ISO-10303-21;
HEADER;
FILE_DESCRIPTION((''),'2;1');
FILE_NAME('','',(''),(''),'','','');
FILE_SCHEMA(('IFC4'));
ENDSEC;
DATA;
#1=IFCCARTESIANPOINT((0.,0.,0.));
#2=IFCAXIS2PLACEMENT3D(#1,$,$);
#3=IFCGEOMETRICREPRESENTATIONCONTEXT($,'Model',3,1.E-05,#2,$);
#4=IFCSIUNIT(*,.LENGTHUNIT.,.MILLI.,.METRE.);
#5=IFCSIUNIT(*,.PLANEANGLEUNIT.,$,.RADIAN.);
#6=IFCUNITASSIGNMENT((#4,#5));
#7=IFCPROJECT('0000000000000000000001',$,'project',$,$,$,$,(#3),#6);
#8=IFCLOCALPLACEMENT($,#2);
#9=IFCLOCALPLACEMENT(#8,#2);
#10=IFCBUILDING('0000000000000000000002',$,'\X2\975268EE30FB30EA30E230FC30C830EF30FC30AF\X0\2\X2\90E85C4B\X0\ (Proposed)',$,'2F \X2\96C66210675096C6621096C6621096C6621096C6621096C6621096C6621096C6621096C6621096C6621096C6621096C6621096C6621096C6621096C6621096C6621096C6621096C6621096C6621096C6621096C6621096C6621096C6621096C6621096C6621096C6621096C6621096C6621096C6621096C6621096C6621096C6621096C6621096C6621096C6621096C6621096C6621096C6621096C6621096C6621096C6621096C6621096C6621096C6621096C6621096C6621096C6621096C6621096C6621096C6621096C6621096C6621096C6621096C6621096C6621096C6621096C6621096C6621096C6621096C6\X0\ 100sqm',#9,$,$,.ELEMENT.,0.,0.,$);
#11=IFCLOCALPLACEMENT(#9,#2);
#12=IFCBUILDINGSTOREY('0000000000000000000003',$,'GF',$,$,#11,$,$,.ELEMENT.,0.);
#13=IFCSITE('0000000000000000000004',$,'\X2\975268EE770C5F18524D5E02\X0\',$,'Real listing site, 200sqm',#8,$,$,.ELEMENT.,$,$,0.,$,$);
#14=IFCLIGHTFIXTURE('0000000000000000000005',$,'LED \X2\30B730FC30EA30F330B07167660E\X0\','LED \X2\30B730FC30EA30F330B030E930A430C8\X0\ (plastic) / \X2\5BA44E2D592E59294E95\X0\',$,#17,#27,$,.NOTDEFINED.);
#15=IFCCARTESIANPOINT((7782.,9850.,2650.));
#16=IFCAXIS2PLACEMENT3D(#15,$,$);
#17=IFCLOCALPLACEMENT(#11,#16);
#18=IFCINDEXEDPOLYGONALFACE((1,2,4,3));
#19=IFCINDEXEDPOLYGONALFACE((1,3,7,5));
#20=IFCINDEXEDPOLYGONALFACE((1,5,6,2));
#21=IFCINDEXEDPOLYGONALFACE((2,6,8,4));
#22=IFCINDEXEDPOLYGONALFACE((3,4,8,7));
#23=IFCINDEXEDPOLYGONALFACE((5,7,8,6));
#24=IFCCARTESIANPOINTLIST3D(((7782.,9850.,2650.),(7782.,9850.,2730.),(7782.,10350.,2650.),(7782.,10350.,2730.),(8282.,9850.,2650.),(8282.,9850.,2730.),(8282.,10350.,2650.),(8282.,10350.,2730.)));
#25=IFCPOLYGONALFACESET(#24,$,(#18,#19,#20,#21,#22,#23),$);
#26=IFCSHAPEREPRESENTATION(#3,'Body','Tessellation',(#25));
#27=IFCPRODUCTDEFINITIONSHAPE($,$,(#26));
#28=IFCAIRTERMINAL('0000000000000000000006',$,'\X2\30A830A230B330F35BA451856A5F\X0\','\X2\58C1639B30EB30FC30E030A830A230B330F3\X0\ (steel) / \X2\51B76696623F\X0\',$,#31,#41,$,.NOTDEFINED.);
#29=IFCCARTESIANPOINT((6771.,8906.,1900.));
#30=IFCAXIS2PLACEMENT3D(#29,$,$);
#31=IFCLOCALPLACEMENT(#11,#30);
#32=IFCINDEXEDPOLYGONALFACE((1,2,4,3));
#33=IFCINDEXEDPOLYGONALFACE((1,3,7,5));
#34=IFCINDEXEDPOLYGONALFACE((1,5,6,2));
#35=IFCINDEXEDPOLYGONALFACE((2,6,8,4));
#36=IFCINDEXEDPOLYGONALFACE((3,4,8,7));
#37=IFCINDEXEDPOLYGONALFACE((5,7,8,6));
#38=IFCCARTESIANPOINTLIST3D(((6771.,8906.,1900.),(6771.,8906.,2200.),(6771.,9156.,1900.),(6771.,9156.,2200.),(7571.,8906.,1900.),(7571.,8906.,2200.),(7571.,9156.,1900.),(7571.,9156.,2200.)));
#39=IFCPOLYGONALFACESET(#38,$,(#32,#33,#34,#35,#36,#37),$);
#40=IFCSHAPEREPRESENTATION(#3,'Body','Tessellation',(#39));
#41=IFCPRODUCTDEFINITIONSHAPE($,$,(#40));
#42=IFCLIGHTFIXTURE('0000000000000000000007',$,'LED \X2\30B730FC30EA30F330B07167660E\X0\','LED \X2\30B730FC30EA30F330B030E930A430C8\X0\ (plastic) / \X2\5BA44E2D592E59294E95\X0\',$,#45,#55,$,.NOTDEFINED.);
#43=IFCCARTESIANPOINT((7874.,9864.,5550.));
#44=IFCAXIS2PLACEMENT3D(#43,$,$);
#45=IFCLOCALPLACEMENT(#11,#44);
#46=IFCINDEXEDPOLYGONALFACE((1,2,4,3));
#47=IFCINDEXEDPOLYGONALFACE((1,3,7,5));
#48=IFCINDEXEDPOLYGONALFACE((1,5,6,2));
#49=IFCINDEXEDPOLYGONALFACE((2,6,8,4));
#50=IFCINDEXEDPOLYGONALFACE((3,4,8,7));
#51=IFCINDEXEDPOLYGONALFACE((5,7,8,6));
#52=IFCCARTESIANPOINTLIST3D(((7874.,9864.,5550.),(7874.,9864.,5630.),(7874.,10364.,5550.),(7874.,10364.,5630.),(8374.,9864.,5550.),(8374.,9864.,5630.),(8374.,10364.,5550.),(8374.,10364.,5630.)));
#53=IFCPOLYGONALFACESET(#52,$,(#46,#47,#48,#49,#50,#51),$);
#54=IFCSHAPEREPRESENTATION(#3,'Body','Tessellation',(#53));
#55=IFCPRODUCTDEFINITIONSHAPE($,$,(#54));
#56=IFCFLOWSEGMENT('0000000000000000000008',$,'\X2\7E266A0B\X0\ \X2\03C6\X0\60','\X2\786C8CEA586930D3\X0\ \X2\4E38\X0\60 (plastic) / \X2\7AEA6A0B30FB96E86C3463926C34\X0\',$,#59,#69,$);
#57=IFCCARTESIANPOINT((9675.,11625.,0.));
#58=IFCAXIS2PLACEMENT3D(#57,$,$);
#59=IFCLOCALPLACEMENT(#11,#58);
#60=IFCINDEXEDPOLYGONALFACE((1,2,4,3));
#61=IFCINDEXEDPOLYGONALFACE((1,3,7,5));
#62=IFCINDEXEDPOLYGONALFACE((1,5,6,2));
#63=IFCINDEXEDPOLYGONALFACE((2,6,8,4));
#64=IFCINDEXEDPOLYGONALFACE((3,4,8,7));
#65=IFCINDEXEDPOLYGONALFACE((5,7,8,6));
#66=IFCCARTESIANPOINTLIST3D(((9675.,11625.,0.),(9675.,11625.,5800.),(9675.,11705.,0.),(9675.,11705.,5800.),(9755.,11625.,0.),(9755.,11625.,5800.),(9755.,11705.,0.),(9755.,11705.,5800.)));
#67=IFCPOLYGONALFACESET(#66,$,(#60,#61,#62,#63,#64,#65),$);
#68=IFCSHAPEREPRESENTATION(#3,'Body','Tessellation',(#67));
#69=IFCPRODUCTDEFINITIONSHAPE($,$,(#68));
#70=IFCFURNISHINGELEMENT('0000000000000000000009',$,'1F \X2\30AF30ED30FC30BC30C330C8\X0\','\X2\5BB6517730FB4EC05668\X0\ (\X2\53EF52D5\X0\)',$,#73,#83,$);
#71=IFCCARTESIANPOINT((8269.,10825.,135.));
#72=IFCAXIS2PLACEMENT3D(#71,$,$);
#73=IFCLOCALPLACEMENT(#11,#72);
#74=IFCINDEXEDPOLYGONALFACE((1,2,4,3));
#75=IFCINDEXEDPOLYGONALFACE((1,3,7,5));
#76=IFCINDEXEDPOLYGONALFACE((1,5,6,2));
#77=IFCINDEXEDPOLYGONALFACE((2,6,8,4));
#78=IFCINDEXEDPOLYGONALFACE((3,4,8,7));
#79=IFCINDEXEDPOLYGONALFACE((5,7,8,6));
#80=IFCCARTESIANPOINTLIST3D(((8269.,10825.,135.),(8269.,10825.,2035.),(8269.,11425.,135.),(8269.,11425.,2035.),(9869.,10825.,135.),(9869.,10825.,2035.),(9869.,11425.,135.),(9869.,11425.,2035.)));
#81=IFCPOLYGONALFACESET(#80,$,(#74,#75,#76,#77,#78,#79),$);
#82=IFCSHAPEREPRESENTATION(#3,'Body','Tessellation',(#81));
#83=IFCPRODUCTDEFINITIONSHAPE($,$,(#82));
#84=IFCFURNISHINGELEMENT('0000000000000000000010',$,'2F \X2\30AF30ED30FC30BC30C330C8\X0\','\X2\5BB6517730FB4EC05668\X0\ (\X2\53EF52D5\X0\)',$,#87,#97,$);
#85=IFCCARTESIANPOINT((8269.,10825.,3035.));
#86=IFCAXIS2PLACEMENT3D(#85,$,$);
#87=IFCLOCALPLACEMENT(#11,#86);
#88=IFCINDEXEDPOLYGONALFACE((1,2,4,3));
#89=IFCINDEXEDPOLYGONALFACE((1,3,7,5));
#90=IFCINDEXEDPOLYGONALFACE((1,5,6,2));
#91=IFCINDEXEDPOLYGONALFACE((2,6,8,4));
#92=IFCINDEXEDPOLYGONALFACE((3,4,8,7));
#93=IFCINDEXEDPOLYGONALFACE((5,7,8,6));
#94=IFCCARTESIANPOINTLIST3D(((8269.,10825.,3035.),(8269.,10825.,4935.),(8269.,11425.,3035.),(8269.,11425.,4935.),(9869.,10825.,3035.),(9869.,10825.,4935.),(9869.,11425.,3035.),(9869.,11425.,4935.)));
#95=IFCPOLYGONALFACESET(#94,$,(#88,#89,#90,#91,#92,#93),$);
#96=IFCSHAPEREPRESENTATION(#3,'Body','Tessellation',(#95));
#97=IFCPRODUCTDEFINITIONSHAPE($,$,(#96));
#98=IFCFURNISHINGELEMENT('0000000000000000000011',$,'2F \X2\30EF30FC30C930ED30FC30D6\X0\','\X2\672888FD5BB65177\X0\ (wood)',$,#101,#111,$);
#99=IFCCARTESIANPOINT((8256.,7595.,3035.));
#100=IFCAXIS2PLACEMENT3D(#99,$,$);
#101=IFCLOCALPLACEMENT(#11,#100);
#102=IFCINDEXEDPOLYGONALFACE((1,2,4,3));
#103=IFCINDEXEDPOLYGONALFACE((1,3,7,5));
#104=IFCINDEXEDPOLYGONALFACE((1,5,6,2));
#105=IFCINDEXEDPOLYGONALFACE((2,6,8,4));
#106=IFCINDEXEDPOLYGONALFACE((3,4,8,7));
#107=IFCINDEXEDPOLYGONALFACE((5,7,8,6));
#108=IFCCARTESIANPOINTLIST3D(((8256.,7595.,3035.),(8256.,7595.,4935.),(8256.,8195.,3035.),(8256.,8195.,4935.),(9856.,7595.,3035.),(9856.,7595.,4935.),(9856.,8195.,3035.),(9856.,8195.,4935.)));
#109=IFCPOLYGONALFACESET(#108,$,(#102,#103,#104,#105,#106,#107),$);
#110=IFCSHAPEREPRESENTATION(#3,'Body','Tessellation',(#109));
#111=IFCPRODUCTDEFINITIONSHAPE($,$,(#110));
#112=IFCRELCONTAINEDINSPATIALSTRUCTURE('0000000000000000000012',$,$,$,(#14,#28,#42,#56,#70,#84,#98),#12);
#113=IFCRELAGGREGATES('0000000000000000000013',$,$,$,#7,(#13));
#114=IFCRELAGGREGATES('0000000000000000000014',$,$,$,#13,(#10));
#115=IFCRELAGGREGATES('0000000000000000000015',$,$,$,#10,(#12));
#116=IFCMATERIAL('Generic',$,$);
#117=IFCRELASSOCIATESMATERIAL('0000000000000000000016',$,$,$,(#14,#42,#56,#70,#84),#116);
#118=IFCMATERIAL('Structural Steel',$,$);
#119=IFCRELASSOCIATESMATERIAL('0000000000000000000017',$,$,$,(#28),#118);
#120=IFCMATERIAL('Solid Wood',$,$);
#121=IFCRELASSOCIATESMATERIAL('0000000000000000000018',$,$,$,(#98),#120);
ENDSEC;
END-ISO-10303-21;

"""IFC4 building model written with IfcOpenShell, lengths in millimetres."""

from ifc_helpers import new_model, si_unit, frame, frame_2d, origin, place, context, project, spatial, rectangle, extrude, material, element, save


model = new_model("IFC4")

# Units and contexts
model_context = context("Model", 3, precision=1e-05, world=origin())
ifc_project = project(units=[si_unit("LENGTHUNIT", "METRE", prefix="MILLI"), si_unit("PLANEANGLEUNIT", "RADIAN")], contexts=[model_context])

# Site, building, storey
site_placement = place(None, origin())
site = spatial("IfcSite", under=ifc_project, at=site_placement, Name="青森県弘前市", ObjectType="Real listing site, 200sqm", CompositionType="ELEMENT", RefElevation=0.0)
building_placement = place(site_placement, origin())
building = spatial("IfcBuilding", under=site, at=building_placement, Name="青森・リモートワーク2部屋 (Proposed)", ObjectType="2F 集成材集成集成集成集成集成集成集成集成集成集成集成集成集成集成集成集成集成集成集成集成集成集成集成集成集成集成集成集成集成集成集成集成集成集成集成集成集成集成集成集成集成集成集成集成集成集成集成集成集成集成集成集成集成集成集成集成集成集成集 100sqm", CompositionType="ELEMENT", ElevationOfRefHeight=0.0, ElevationOfTerrain=0.0)
storey_placement = place(building_placement, origin())
storey = spatial("IfcBuildingStorey", under=building, at=storey_placement, Name="GF", CompositionType="ELEMENT", Elevation=0.0)

# Shared definitions
ifc_material_1 = material(Name="Solid Wood")

# Shared definitions
ifc_material_2 = material(Name="Structural Steel")

# Shared definitions
ifc_material_3 = material(Name="Generic")

# Light fixture
light_fixture_1_placement = place(storey_placement, frame((7782.0, 9850.0, 2650.0)))
element("IfcLightFixture", 1, at=light_fixture_1_placement, inside=storey, material=ifc_material_3, Name="LED シーリング照明", Description="LED シーリングライト (plastic) / 室中央天井", PredefinedType="NOTDEFINED", context=model_context, shape_type="SweptSolid", body=[
    extrude(rectangle(XDim=500.0, YDim=500.0, at=frame_2d((250.0, 250.0))), frame((7782.0, 9850.0, 2650.0)), (0.0, 0.0, 1.0), 80.0),
])

# Air terminal
air_terminal_placement = place(storey_placement, frame((6771.0, 8906.0, 1900.0)))
element("IfcAirTerminal", 2, at=air_terminal_placement, inside=storey, material=ifc_material_2, Name="エアコン室内機", Description="壁掛ルームエアコン (steel) / 冷暖房", PredefinedType="NOTDEFINED", context=model_context, shape_type="SweptSolid", body=[
    extrude(rectangle(XDim=800.0, YDim=250.0, at=frame_2d((400.0, 125.0))), frame((6771.0, 8906.0, 1900.0)), (0.0, 0.0, 1.0), 300.0),
])

# Light fixture
light_fixture_2_placement = place(storey_placement, frame((7874.0, 9864.0, 5550.0)))
element("IfcLightFixture", 3, at=light_fixture_2_placement, inside=storey, material=ifc_material_3, Name="LED シーリング照明", Description="LED シーリングライト (plastic) / 室中央天井", PredefinedType="NOTDEFINED", context=model_context, shape_type="SweptSolid", body=[
    extrude(rectangle(XDim=500.0, YDim=500.0, at=frame_2d((250.0, 250.0))), frame((7874.0, 9864.0, 5550.0)), (0.0, 0.0, 1.0), 80.0),
])

# Flow segment
flow_segment_placement = place(storey_placement, frame((9675.0, 11625.0, 0.0)))
element("IfcFlowSegment", 4, at=flow_segment_placement, inside=storey, material=ifc_material_3, Name="縦樋 φ60", Description="硬質塩ビ 丸60 (plastic) / 竪樋・雨水排水", context=model_context, shape_type="SweptSolid", body=[
    extrude(rectangle(XDim=80.0, YDim=80.0, at=frame_2d((40.0, 40.0))), frame((9675.0, 11625.0, 0.0)), (0.0, 0.0, 1.0), 5800.0),
])

# Furnishing elements
furnishing_1_placement = place(storey_placement, frame((8269.0, 10825.0, 135.0)))
element("IfcFurnishingElement", 5, at=furnishing_1_placement, inside=storey, material=ifc_material_3, Name="1F クローゼット", Description="家具・什器 (可動)", context=model_context, shape_type="SweptSolid", body=[
    extrude(rectangle(XDim=1600.0, YDim=600.0, at=frame_2d((800.0, 300.0))), frame((8269.0, 10825.0, 135.0)), (0.0, 0.0, 1.0), 1900.0),
])
furnishing_2_placement = place(storey_placement, frame((8269.0, 10825.0, 3035.0)))
element("IfcFurnishingElement", 6, at=furnishing_2_placement, inside=storey, material=ifc_material_3, Name="2F クローゼット", Description="家具・什器 (可動)", context=model_context, shape_type="SweptSolid", body=[
    extrude(rectangle(XDim=1600.0, YDim=600.0, at=frame_2d((800.0, 300.0))), frame((8269.0, 10825.0, 3035.0)), (0.0, 0.0, 1.0), 1900.0),
])
furnishing_3_placement = place(storey_placement, frame((8256.0, 7595.0, 3035.0)))
element("IfcFurnishingElement", 7, at=furnishing_3_placement, inside=storey, material=ifc_material_1, Name="2F ワードローブ", Description="木製家具 (wood)", context=model_context, shape_type="SweptSolid", body=[
    extrude(rectangle(XDim=1600.0, YDim=600.0, at=frame_2d((800.0, 300.0))), frame((8256.0, 7595.0, 3035.0)), (0.0, 0.0, 1.0), 1900.0),
])

save(model, "model.ifc")
